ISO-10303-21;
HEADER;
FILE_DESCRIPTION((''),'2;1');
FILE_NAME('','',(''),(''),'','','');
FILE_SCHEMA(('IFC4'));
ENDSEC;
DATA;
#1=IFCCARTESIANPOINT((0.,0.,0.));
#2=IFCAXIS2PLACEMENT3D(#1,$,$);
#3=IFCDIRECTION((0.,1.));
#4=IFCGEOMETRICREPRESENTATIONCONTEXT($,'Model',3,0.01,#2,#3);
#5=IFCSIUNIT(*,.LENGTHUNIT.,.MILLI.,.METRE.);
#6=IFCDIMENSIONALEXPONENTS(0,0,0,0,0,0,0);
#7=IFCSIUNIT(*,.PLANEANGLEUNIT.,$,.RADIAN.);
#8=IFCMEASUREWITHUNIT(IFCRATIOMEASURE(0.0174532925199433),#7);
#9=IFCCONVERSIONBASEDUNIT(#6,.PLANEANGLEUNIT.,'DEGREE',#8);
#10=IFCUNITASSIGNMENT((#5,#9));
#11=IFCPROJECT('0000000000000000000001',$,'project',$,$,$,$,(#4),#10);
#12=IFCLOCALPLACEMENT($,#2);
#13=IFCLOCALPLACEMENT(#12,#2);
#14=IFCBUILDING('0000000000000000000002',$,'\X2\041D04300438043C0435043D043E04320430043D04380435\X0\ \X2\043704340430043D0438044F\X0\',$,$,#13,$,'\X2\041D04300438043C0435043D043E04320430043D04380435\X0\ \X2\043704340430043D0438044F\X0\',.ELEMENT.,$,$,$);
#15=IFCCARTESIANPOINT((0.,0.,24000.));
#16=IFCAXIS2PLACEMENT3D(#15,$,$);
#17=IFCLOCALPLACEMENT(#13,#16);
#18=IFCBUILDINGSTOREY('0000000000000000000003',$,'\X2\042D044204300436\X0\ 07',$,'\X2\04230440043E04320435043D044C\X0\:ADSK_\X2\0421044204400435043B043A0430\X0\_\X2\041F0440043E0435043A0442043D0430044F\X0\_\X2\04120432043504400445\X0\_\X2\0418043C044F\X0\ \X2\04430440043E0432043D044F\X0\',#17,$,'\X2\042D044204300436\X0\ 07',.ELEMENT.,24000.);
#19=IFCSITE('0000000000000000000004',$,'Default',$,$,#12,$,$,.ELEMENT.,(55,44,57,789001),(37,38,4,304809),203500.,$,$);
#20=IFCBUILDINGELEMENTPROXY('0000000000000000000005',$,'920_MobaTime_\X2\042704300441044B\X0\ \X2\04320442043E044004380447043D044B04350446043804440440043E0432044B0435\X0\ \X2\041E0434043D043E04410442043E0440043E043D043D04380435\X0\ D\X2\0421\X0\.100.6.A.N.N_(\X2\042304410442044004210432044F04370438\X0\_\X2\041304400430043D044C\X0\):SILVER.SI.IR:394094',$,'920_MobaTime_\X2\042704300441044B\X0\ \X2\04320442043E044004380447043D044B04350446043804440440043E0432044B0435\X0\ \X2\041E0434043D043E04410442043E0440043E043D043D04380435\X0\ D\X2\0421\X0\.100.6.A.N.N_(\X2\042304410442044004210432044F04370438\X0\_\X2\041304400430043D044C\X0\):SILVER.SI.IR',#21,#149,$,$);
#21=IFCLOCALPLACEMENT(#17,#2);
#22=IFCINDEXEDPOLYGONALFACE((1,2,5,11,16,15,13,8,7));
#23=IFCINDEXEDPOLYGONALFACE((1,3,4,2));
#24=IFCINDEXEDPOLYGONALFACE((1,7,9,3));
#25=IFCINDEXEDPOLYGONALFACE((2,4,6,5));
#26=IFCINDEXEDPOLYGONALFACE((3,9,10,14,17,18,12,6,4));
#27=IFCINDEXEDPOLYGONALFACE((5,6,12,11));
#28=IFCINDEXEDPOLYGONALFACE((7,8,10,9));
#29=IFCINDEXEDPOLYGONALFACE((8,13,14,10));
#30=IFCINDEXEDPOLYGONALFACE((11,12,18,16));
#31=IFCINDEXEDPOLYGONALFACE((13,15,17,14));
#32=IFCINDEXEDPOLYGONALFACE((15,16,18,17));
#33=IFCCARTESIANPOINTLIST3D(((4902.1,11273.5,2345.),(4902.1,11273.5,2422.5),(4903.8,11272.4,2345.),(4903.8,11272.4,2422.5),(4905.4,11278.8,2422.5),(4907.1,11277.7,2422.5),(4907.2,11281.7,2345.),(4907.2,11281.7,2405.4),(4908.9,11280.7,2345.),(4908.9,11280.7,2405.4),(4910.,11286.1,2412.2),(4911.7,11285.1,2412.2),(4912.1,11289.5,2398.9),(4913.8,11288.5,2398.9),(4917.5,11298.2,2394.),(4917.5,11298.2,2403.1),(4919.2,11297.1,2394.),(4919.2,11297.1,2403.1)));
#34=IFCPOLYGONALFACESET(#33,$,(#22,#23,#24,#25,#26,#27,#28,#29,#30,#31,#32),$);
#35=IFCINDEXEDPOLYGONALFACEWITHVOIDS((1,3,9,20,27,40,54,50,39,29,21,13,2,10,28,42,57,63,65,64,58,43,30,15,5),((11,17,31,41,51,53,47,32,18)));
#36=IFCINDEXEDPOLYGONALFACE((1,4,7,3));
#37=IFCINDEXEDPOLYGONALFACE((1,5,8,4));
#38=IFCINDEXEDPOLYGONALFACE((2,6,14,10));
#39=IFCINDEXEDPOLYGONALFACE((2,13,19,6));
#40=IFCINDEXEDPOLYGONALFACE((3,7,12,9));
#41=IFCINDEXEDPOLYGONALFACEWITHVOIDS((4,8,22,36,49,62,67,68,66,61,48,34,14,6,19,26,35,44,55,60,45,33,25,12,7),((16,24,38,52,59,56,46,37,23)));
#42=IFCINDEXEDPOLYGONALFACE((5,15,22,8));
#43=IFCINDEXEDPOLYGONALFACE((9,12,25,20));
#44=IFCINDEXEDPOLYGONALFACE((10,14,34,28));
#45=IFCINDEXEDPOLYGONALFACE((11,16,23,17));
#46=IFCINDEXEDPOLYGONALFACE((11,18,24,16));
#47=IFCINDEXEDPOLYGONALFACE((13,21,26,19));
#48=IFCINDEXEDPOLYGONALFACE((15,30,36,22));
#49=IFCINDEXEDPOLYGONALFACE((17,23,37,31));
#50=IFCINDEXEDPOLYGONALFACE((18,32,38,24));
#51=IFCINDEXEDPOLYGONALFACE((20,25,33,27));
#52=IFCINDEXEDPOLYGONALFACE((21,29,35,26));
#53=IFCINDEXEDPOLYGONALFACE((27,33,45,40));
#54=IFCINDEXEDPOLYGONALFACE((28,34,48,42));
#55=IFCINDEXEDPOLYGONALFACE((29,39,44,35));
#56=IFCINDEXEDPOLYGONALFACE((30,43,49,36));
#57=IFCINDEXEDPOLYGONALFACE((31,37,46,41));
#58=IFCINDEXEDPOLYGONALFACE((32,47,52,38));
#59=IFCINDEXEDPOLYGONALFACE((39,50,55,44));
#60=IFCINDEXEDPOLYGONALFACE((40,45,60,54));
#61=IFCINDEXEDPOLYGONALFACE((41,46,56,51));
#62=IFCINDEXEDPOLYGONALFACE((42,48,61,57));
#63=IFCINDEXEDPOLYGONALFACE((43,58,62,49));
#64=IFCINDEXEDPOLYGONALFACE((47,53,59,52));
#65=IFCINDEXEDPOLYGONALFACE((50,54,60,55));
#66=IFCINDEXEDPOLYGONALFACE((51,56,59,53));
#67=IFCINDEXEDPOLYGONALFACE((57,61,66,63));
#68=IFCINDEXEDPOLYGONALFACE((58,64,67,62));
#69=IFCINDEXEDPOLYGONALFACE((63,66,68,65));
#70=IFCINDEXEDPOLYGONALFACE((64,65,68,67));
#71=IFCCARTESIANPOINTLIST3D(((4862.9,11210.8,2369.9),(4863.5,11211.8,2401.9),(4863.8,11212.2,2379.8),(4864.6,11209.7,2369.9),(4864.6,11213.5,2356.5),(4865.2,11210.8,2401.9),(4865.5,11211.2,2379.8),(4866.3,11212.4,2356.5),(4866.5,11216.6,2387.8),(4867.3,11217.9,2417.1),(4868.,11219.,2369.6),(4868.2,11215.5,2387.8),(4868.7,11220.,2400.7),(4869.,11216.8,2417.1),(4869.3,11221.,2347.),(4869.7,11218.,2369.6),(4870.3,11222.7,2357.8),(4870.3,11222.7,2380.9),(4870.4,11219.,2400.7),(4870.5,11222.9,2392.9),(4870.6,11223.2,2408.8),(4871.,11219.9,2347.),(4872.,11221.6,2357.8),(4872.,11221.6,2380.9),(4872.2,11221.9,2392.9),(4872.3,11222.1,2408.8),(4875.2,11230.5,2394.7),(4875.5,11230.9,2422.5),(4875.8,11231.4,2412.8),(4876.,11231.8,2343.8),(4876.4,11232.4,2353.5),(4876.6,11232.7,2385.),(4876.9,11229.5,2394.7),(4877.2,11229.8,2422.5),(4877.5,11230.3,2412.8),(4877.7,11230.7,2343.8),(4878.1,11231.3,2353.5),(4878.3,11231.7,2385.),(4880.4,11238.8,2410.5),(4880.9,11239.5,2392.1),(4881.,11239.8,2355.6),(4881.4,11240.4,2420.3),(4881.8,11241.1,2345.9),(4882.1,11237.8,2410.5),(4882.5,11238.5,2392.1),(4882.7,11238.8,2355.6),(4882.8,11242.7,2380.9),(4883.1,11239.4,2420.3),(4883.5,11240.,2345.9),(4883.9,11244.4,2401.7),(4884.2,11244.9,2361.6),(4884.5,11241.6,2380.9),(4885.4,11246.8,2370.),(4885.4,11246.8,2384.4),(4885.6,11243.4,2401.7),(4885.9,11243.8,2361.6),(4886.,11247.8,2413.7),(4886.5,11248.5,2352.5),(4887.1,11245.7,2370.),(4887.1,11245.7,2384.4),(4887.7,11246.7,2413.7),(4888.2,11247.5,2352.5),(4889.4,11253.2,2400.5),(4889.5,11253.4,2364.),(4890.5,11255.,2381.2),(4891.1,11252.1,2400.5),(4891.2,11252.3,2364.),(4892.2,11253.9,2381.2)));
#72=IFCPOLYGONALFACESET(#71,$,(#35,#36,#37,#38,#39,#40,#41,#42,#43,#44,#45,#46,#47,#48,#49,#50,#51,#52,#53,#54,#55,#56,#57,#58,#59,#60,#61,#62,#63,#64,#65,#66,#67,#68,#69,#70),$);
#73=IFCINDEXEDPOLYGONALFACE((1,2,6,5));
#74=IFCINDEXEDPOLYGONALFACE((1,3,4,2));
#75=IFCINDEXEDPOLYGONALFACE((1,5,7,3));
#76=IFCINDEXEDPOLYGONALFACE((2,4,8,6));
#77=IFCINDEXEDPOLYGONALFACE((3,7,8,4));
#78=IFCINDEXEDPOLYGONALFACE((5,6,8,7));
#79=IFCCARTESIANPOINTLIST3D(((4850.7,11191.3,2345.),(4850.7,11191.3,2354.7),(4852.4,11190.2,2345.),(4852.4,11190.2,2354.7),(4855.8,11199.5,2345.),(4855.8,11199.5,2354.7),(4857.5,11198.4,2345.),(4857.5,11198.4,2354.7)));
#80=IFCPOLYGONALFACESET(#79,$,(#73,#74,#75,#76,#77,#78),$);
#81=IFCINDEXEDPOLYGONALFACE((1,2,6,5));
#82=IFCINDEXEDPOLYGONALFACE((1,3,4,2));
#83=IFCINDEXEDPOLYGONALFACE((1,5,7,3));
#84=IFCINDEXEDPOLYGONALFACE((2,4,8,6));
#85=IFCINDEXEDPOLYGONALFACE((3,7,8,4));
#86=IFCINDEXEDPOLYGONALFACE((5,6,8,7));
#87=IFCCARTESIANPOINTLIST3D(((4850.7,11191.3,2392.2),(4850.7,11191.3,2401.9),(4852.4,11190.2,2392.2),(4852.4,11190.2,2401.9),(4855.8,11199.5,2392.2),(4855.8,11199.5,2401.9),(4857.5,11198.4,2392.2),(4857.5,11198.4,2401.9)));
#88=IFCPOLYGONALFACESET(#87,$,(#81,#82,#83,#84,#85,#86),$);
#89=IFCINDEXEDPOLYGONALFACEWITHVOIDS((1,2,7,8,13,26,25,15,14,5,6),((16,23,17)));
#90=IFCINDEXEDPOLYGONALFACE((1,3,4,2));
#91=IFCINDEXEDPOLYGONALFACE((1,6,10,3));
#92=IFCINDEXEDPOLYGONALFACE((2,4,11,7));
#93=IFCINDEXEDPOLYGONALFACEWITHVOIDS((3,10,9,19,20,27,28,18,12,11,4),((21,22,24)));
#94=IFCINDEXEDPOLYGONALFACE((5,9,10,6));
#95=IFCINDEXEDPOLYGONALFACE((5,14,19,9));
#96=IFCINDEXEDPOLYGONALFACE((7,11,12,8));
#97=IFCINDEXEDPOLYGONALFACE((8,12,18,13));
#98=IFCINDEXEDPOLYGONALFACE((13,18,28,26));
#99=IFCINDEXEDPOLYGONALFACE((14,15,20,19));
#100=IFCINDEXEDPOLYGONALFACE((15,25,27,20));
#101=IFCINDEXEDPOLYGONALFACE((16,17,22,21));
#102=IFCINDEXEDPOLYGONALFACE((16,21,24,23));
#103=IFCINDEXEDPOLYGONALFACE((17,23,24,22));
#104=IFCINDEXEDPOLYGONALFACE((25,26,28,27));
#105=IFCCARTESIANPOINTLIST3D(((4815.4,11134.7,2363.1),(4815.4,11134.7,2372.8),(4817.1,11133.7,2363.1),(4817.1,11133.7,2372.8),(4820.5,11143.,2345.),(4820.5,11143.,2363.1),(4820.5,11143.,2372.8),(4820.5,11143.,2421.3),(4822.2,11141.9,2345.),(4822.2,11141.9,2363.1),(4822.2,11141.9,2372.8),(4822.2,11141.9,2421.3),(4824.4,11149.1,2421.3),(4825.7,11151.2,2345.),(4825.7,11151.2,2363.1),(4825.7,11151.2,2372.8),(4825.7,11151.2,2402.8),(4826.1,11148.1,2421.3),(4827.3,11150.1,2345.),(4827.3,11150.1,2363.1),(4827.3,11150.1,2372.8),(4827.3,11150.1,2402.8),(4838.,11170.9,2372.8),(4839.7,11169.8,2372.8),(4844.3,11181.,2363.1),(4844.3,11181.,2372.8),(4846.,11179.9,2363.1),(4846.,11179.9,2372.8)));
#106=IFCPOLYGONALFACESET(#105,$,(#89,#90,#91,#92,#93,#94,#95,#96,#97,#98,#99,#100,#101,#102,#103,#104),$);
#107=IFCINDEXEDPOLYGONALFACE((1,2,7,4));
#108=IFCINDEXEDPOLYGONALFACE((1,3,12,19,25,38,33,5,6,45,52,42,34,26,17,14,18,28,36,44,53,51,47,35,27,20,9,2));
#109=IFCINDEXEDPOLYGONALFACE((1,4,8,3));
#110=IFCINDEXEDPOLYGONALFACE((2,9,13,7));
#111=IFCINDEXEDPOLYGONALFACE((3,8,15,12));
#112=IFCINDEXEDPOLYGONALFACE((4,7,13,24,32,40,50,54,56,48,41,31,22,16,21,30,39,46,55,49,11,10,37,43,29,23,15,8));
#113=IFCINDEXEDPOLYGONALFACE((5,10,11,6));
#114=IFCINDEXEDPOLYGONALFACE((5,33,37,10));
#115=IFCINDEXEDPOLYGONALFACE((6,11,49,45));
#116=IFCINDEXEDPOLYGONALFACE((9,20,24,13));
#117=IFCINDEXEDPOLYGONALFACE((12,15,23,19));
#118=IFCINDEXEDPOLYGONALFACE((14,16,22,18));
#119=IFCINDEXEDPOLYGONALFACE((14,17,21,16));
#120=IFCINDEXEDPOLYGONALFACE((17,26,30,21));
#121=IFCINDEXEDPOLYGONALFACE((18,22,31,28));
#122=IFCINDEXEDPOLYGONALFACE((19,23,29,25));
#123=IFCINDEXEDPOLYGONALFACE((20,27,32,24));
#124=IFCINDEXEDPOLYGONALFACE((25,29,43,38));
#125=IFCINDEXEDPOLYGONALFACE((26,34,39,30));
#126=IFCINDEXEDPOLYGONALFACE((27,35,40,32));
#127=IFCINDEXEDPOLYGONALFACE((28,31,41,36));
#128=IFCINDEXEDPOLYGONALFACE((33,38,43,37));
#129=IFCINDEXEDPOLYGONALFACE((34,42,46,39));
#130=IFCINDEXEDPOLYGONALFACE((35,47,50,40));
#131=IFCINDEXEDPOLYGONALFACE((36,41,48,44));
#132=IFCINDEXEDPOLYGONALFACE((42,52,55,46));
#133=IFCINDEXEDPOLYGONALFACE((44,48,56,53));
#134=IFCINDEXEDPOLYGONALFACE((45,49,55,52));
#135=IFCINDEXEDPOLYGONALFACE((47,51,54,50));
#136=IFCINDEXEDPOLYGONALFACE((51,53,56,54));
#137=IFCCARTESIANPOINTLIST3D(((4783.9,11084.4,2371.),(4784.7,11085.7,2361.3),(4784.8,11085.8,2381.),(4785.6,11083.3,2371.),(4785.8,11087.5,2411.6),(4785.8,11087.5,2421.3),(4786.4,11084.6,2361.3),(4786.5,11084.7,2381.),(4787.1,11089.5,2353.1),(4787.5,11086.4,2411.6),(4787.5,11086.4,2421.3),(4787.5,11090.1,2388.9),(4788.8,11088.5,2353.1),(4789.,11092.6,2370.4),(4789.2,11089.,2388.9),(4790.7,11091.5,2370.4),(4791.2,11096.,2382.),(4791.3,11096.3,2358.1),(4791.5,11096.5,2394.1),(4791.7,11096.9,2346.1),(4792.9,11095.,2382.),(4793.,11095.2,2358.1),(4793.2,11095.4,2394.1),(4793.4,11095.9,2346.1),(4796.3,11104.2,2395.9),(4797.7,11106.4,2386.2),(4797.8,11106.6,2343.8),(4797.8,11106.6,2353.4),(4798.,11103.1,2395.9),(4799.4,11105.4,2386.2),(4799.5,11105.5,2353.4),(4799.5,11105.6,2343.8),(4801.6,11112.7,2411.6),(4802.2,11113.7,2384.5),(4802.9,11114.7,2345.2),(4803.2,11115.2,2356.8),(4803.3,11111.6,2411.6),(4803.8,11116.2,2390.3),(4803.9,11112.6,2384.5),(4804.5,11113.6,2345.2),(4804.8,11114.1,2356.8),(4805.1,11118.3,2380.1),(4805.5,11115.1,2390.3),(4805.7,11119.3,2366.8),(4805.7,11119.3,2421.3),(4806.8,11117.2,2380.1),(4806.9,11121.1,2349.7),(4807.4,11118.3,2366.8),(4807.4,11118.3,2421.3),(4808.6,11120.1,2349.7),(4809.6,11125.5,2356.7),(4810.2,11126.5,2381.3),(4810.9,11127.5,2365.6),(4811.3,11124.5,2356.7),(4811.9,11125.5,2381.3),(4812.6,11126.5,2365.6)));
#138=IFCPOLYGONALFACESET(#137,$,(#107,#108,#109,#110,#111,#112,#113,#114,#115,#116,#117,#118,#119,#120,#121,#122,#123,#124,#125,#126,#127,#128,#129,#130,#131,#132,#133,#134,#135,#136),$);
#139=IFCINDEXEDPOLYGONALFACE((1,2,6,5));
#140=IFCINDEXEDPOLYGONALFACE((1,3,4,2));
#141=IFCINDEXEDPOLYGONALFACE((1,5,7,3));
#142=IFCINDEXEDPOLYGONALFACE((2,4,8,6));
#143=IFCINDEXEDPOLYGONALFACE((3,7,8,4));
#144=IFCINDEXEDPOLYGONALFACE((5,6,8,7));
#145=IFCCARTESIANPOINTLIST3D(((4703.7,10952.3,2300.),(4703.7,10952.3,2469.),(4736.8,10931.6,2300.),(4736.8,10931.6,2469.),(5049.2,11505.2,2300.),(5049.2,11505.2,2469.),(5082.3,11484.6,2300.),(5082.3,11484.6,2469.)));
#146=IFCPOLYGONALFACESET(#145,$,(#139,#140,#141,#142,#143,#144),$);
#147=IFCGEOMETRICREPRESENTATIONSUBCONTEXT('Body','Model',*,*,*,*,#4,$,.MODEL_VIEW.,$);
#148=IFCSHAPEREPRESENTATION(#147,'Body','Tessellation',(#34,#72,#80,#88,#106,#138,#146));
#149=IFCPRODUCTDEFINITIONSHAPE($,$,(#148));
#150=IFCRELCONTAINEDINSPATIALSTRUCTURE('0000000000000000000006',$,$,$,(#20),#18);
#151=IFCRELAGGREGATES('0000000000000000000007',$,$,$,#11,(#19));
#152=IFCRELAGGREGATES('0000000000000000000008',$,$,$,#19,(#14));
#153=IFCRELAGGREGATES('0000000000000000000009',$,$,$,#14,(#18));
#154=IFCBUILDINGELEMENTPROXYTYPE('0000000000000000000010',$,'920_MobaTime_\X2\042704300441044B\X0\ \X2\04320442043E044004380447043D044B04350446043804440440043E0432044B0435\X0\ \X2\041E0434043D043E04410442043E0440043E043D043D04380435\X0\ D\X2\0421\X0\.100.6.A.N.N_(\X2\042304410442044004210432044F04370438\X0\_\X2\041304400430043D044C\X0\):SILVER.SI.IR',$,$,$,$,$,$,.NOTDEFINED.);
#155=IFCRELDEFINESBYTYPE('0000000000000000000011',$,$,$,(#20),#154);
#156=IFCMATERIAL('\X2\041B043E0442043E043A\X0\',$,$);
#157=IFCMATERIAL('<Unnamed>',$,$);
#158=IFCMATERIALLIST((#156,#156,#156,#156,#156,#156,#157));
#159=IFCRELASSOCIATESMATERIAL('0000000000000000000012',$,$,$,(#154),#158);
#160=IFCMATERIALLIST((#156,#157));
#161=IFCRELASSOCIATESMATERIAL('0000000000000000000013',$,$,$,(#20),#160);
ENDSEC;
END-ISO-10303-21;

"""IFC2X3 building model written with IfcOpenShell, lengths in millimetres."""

from ifc_helpers import new_model, entity, si_unit, converted_unit, direction, frame, origin, origin_2d_with_axis, place, context, subcontext, project, spatial, polyline, rectangle, outline, extrude, source, transform, mapped, material, material_list, type_object, type_shapes, element, save


model = new_model("IFC2X3")

# Units and contexts
model_context = context("Model", 3, precision=0.01, world=origin(), true_north=direction((0.0, 1.0)))
body_context = subcontext(model_context, "Body", "Model", "MODEL_VIEW")
ifc_project = project(units=[si_unit("LENGTHUNIT", "METRE", prefix="MILLI"), converted_unit("PLANEANGLEUNIT", "DEGREE", entity("IfcRatioMeasure", 0.0174532925199433), si_unit("PLANEANGLEUNIT", "RADIAN"), dimensions=[0, 0, 0, 0, 0, 0, 0])], contexts=[model_context])

# Site, building, storey
site_placement = place(None, origin())
site = spatial("IfcSite", under=ifc_project, at=site_placement, Name="Default", CompositionType="ELEMENT", RefLatitude=(55, 44, 57, 789001), RefLongitude=(37, 38, 4, 304809), RefElevation=203500.0)
building_placement = place(site_placement, origin())
building = spatial("IfcBuilding", under=site, at=building_placement, Name="Наименование здания", LongName="Наименование здания", CompositionType="ELEMENT")
storey_placement = place(building_placement, frame((0.0, 0.0, 24000.0)))
storey = spatial("IfcBuildingStorey", under=building, at=storey_placement, Name="Этаж 07", ObjectType="Уровень:ADSK_Стрелка_Проектная_Вверх_Имя уровня", LongName="Этаж 07", CompositionType="ELEMENT", Elevation=24000.0)

# Building element proxy
ifc_material_1 = material(Name="Лоток")
ifc_material_2 = material(Name="<Unnamed>")
ifc_material_list_1 = material_list([ifc_material_1, ifc_material_2])
ifc_material_list_2 = material_list([ifc_material_1, ifc_material_1, ifc_material_1, ifc_material_1, ifc_material_1, ifc_material_1, ifc_material_2])
building_element_proxy_type = type_object("IfcBuildingElementProxyType", Name="920_MobaTime_Часы вторичныецифровые Односторонние DС.100.6.A.N.N_(УстрСвязи_Грань):SILVER.SI.IR", PredefinedType="NOTDEFINED", material=ifc_material_list_2)
shared_shape = source(origin(), body_context, "Body", "SweptSolid", [
    extrude(outline(polyline([(-49.3, -13.1), (28.2, -13.1), (28.2, -6.8), (17.9, 1.8), (8.8, 16.0), (-0.3, 16.0), (4.6, 5.8), (11.1, -3.4), (-49.3, -3.4), (-49.3, -13.1)])), frame((-64.6, 9.8, 39.0), z_axis=(0.0, 0.0, 1.0), x_axis=(0.0, 1.0, 0.0)), (0.0, 0.0, 1.0), 2.0),
    extrude(outline(polyline([(2.2, -27.6), (19.0, -27.6), (30.5, -16.1), (33.3, -4.9), (31.0, 5.8), (21.8, 17.2), (5.2, 27.3), (-11.1, 33.0), (-24.0, 32.7), (-33.6, 27.6), (-40.3, 18.6), (-42.8, 5.7), (-38.0, -6.3), (-27.2, -14.9), (-17.5, -17.7), (-8.2, -16.4), (-0.3, -11.9), (5.1, -4.5), (7.3, 6.2), (4.0, 17.2), (18.4, 7.3), (23.6, -2.4), (22.0, -11.4), (14.2, -18.4), (5.3, -18.3), (2.2, -27.6)]), holes=[polyline([(-9.0, 23.3), (-1.3, 14.3), (-2.5, 2.0), (-11.4, -7.0), (-23.4, -6.0), (-32.2, 2.9), (-31.2, 15.1), (-25.6, 22.1), (-17.5, 24.9), (-9.0, 23.3)])]), frame((-2.7, 3.6, 39.0), z_axis=(0.0, 0.0, 1.0), x_axis=(-0.427649, 0.903945, 0.0)), (0.0, 0.0, 1.0), 2.0),
    extrude(rectangle(XDim=9.7, YDim=9.7, at=origin_2d_with_axis()), frame((40.6, -34.7, 39.0)), (0.0, 0.0, 1.0), 2.0),
    extrude(rectangle(XDim=9.7, YDim=9.7, at=origin_2d_with_axis()), frame((40.6, 12.6, 39.0)), (0.0, 0.0, 1.0), 2.0),
    extrude(outline(polyline([(-0.9, -28.1), (8.8, -28.1), (8.8, -9.9), (18.5, -9.9), (18.5, -0.2), (8.8, -0.2), (8.8, 48.3), (1.5, 48.3), (-36.0, -0.2), (-36.0, -9.9), (-0.9, -9.9), (-0.9, -28.1)]), holes=[polyline([(-0.9, -0.2), (-24.1, -0.2), (-0.9, 29.7), (-0.9, -0.2)])]), frame((93.6, -11.4, 39.0)), (0.0, 0.0, 1.0), 2.0),
    extrude(outline(polyline([(3.3, -28.3), (12.5, -28.3), (20.5, -25.0), (26.8, -18.9), (30.7, -10.0), (31.4, 1.6), (26.9, 11.8), (20.1, 18.4), (11.1, 22.3), (1.0, 23.3), (-7.9, 20.4), (-14.9, 14.5), (-18.9, 6.2), (-17.1, -9.0), (-36.7, 0.5), (-29.1, 29.2), (-38.5, 31.7), (-48.1, -4.6), (-11.6, -23.1), (-8.0, -14.0), (-10.8, -7.6), (-10.2, 1.1), (-3.0, 11.8), (9.2, 12.8), (20.0, 5.5), (21.4, -7.5), (15.5, -16.4), (4.6, -18.6), (3.3, -28.3)])), frame((147.1, -8.5, 39.0), z_axis=(0.0, 0.0, 1.0), x_axis=(0.256974, -0.966418, 0.0)), (0.0, 0.0, 1.0), 2.0),
    extrude(rectangle(XDim=652.0, YDim=169.0, at=origin_2d_with_axis()), frame((0.0, 0.0, 0.0), z_axis=(0.0, 0.0, 1.0), x_axis=(-1.0, 0.0, 0.0)), (0.0, 0.0, 1.0), 39.0),
])
type_shapes(building_element_proxy_type, [shared_shape])
for number, where, z_axis, x_axis, name in (
    (1, (4909.6, 11208.1, 2384.5), (-0.848048, 0.52992, 0.0), (-0.52992, -0.848048, 0.0), "920_MobaTime_Часы вторичныецифровые Односторонние DС.100.6.A.N.N_(УстрСвязи_Грань):SILVER.SI.IR:394094"),
):
    element("IfcBuildingElementProxy", number, at=place(storey_placement, frame(where, z_axis=z_axis, x_axis=x_axis)), inside=storey, type_object=building_element_proxy_type, material=ifc_material_list_1, Name=name, ObjectType="920_MobaTime_Часы вторичныецифровые Односторонние DС.100.6.A.N.N_(УстрСвязи_Грань):SILVER.SI.IR", context=body_context, shape_type="MappedRepresentation", body=[
        mapped(shared_shape, transform((0.0, 0.0, 0.0), scale=1.0)),
    ])

save(model, "model.ifc")
